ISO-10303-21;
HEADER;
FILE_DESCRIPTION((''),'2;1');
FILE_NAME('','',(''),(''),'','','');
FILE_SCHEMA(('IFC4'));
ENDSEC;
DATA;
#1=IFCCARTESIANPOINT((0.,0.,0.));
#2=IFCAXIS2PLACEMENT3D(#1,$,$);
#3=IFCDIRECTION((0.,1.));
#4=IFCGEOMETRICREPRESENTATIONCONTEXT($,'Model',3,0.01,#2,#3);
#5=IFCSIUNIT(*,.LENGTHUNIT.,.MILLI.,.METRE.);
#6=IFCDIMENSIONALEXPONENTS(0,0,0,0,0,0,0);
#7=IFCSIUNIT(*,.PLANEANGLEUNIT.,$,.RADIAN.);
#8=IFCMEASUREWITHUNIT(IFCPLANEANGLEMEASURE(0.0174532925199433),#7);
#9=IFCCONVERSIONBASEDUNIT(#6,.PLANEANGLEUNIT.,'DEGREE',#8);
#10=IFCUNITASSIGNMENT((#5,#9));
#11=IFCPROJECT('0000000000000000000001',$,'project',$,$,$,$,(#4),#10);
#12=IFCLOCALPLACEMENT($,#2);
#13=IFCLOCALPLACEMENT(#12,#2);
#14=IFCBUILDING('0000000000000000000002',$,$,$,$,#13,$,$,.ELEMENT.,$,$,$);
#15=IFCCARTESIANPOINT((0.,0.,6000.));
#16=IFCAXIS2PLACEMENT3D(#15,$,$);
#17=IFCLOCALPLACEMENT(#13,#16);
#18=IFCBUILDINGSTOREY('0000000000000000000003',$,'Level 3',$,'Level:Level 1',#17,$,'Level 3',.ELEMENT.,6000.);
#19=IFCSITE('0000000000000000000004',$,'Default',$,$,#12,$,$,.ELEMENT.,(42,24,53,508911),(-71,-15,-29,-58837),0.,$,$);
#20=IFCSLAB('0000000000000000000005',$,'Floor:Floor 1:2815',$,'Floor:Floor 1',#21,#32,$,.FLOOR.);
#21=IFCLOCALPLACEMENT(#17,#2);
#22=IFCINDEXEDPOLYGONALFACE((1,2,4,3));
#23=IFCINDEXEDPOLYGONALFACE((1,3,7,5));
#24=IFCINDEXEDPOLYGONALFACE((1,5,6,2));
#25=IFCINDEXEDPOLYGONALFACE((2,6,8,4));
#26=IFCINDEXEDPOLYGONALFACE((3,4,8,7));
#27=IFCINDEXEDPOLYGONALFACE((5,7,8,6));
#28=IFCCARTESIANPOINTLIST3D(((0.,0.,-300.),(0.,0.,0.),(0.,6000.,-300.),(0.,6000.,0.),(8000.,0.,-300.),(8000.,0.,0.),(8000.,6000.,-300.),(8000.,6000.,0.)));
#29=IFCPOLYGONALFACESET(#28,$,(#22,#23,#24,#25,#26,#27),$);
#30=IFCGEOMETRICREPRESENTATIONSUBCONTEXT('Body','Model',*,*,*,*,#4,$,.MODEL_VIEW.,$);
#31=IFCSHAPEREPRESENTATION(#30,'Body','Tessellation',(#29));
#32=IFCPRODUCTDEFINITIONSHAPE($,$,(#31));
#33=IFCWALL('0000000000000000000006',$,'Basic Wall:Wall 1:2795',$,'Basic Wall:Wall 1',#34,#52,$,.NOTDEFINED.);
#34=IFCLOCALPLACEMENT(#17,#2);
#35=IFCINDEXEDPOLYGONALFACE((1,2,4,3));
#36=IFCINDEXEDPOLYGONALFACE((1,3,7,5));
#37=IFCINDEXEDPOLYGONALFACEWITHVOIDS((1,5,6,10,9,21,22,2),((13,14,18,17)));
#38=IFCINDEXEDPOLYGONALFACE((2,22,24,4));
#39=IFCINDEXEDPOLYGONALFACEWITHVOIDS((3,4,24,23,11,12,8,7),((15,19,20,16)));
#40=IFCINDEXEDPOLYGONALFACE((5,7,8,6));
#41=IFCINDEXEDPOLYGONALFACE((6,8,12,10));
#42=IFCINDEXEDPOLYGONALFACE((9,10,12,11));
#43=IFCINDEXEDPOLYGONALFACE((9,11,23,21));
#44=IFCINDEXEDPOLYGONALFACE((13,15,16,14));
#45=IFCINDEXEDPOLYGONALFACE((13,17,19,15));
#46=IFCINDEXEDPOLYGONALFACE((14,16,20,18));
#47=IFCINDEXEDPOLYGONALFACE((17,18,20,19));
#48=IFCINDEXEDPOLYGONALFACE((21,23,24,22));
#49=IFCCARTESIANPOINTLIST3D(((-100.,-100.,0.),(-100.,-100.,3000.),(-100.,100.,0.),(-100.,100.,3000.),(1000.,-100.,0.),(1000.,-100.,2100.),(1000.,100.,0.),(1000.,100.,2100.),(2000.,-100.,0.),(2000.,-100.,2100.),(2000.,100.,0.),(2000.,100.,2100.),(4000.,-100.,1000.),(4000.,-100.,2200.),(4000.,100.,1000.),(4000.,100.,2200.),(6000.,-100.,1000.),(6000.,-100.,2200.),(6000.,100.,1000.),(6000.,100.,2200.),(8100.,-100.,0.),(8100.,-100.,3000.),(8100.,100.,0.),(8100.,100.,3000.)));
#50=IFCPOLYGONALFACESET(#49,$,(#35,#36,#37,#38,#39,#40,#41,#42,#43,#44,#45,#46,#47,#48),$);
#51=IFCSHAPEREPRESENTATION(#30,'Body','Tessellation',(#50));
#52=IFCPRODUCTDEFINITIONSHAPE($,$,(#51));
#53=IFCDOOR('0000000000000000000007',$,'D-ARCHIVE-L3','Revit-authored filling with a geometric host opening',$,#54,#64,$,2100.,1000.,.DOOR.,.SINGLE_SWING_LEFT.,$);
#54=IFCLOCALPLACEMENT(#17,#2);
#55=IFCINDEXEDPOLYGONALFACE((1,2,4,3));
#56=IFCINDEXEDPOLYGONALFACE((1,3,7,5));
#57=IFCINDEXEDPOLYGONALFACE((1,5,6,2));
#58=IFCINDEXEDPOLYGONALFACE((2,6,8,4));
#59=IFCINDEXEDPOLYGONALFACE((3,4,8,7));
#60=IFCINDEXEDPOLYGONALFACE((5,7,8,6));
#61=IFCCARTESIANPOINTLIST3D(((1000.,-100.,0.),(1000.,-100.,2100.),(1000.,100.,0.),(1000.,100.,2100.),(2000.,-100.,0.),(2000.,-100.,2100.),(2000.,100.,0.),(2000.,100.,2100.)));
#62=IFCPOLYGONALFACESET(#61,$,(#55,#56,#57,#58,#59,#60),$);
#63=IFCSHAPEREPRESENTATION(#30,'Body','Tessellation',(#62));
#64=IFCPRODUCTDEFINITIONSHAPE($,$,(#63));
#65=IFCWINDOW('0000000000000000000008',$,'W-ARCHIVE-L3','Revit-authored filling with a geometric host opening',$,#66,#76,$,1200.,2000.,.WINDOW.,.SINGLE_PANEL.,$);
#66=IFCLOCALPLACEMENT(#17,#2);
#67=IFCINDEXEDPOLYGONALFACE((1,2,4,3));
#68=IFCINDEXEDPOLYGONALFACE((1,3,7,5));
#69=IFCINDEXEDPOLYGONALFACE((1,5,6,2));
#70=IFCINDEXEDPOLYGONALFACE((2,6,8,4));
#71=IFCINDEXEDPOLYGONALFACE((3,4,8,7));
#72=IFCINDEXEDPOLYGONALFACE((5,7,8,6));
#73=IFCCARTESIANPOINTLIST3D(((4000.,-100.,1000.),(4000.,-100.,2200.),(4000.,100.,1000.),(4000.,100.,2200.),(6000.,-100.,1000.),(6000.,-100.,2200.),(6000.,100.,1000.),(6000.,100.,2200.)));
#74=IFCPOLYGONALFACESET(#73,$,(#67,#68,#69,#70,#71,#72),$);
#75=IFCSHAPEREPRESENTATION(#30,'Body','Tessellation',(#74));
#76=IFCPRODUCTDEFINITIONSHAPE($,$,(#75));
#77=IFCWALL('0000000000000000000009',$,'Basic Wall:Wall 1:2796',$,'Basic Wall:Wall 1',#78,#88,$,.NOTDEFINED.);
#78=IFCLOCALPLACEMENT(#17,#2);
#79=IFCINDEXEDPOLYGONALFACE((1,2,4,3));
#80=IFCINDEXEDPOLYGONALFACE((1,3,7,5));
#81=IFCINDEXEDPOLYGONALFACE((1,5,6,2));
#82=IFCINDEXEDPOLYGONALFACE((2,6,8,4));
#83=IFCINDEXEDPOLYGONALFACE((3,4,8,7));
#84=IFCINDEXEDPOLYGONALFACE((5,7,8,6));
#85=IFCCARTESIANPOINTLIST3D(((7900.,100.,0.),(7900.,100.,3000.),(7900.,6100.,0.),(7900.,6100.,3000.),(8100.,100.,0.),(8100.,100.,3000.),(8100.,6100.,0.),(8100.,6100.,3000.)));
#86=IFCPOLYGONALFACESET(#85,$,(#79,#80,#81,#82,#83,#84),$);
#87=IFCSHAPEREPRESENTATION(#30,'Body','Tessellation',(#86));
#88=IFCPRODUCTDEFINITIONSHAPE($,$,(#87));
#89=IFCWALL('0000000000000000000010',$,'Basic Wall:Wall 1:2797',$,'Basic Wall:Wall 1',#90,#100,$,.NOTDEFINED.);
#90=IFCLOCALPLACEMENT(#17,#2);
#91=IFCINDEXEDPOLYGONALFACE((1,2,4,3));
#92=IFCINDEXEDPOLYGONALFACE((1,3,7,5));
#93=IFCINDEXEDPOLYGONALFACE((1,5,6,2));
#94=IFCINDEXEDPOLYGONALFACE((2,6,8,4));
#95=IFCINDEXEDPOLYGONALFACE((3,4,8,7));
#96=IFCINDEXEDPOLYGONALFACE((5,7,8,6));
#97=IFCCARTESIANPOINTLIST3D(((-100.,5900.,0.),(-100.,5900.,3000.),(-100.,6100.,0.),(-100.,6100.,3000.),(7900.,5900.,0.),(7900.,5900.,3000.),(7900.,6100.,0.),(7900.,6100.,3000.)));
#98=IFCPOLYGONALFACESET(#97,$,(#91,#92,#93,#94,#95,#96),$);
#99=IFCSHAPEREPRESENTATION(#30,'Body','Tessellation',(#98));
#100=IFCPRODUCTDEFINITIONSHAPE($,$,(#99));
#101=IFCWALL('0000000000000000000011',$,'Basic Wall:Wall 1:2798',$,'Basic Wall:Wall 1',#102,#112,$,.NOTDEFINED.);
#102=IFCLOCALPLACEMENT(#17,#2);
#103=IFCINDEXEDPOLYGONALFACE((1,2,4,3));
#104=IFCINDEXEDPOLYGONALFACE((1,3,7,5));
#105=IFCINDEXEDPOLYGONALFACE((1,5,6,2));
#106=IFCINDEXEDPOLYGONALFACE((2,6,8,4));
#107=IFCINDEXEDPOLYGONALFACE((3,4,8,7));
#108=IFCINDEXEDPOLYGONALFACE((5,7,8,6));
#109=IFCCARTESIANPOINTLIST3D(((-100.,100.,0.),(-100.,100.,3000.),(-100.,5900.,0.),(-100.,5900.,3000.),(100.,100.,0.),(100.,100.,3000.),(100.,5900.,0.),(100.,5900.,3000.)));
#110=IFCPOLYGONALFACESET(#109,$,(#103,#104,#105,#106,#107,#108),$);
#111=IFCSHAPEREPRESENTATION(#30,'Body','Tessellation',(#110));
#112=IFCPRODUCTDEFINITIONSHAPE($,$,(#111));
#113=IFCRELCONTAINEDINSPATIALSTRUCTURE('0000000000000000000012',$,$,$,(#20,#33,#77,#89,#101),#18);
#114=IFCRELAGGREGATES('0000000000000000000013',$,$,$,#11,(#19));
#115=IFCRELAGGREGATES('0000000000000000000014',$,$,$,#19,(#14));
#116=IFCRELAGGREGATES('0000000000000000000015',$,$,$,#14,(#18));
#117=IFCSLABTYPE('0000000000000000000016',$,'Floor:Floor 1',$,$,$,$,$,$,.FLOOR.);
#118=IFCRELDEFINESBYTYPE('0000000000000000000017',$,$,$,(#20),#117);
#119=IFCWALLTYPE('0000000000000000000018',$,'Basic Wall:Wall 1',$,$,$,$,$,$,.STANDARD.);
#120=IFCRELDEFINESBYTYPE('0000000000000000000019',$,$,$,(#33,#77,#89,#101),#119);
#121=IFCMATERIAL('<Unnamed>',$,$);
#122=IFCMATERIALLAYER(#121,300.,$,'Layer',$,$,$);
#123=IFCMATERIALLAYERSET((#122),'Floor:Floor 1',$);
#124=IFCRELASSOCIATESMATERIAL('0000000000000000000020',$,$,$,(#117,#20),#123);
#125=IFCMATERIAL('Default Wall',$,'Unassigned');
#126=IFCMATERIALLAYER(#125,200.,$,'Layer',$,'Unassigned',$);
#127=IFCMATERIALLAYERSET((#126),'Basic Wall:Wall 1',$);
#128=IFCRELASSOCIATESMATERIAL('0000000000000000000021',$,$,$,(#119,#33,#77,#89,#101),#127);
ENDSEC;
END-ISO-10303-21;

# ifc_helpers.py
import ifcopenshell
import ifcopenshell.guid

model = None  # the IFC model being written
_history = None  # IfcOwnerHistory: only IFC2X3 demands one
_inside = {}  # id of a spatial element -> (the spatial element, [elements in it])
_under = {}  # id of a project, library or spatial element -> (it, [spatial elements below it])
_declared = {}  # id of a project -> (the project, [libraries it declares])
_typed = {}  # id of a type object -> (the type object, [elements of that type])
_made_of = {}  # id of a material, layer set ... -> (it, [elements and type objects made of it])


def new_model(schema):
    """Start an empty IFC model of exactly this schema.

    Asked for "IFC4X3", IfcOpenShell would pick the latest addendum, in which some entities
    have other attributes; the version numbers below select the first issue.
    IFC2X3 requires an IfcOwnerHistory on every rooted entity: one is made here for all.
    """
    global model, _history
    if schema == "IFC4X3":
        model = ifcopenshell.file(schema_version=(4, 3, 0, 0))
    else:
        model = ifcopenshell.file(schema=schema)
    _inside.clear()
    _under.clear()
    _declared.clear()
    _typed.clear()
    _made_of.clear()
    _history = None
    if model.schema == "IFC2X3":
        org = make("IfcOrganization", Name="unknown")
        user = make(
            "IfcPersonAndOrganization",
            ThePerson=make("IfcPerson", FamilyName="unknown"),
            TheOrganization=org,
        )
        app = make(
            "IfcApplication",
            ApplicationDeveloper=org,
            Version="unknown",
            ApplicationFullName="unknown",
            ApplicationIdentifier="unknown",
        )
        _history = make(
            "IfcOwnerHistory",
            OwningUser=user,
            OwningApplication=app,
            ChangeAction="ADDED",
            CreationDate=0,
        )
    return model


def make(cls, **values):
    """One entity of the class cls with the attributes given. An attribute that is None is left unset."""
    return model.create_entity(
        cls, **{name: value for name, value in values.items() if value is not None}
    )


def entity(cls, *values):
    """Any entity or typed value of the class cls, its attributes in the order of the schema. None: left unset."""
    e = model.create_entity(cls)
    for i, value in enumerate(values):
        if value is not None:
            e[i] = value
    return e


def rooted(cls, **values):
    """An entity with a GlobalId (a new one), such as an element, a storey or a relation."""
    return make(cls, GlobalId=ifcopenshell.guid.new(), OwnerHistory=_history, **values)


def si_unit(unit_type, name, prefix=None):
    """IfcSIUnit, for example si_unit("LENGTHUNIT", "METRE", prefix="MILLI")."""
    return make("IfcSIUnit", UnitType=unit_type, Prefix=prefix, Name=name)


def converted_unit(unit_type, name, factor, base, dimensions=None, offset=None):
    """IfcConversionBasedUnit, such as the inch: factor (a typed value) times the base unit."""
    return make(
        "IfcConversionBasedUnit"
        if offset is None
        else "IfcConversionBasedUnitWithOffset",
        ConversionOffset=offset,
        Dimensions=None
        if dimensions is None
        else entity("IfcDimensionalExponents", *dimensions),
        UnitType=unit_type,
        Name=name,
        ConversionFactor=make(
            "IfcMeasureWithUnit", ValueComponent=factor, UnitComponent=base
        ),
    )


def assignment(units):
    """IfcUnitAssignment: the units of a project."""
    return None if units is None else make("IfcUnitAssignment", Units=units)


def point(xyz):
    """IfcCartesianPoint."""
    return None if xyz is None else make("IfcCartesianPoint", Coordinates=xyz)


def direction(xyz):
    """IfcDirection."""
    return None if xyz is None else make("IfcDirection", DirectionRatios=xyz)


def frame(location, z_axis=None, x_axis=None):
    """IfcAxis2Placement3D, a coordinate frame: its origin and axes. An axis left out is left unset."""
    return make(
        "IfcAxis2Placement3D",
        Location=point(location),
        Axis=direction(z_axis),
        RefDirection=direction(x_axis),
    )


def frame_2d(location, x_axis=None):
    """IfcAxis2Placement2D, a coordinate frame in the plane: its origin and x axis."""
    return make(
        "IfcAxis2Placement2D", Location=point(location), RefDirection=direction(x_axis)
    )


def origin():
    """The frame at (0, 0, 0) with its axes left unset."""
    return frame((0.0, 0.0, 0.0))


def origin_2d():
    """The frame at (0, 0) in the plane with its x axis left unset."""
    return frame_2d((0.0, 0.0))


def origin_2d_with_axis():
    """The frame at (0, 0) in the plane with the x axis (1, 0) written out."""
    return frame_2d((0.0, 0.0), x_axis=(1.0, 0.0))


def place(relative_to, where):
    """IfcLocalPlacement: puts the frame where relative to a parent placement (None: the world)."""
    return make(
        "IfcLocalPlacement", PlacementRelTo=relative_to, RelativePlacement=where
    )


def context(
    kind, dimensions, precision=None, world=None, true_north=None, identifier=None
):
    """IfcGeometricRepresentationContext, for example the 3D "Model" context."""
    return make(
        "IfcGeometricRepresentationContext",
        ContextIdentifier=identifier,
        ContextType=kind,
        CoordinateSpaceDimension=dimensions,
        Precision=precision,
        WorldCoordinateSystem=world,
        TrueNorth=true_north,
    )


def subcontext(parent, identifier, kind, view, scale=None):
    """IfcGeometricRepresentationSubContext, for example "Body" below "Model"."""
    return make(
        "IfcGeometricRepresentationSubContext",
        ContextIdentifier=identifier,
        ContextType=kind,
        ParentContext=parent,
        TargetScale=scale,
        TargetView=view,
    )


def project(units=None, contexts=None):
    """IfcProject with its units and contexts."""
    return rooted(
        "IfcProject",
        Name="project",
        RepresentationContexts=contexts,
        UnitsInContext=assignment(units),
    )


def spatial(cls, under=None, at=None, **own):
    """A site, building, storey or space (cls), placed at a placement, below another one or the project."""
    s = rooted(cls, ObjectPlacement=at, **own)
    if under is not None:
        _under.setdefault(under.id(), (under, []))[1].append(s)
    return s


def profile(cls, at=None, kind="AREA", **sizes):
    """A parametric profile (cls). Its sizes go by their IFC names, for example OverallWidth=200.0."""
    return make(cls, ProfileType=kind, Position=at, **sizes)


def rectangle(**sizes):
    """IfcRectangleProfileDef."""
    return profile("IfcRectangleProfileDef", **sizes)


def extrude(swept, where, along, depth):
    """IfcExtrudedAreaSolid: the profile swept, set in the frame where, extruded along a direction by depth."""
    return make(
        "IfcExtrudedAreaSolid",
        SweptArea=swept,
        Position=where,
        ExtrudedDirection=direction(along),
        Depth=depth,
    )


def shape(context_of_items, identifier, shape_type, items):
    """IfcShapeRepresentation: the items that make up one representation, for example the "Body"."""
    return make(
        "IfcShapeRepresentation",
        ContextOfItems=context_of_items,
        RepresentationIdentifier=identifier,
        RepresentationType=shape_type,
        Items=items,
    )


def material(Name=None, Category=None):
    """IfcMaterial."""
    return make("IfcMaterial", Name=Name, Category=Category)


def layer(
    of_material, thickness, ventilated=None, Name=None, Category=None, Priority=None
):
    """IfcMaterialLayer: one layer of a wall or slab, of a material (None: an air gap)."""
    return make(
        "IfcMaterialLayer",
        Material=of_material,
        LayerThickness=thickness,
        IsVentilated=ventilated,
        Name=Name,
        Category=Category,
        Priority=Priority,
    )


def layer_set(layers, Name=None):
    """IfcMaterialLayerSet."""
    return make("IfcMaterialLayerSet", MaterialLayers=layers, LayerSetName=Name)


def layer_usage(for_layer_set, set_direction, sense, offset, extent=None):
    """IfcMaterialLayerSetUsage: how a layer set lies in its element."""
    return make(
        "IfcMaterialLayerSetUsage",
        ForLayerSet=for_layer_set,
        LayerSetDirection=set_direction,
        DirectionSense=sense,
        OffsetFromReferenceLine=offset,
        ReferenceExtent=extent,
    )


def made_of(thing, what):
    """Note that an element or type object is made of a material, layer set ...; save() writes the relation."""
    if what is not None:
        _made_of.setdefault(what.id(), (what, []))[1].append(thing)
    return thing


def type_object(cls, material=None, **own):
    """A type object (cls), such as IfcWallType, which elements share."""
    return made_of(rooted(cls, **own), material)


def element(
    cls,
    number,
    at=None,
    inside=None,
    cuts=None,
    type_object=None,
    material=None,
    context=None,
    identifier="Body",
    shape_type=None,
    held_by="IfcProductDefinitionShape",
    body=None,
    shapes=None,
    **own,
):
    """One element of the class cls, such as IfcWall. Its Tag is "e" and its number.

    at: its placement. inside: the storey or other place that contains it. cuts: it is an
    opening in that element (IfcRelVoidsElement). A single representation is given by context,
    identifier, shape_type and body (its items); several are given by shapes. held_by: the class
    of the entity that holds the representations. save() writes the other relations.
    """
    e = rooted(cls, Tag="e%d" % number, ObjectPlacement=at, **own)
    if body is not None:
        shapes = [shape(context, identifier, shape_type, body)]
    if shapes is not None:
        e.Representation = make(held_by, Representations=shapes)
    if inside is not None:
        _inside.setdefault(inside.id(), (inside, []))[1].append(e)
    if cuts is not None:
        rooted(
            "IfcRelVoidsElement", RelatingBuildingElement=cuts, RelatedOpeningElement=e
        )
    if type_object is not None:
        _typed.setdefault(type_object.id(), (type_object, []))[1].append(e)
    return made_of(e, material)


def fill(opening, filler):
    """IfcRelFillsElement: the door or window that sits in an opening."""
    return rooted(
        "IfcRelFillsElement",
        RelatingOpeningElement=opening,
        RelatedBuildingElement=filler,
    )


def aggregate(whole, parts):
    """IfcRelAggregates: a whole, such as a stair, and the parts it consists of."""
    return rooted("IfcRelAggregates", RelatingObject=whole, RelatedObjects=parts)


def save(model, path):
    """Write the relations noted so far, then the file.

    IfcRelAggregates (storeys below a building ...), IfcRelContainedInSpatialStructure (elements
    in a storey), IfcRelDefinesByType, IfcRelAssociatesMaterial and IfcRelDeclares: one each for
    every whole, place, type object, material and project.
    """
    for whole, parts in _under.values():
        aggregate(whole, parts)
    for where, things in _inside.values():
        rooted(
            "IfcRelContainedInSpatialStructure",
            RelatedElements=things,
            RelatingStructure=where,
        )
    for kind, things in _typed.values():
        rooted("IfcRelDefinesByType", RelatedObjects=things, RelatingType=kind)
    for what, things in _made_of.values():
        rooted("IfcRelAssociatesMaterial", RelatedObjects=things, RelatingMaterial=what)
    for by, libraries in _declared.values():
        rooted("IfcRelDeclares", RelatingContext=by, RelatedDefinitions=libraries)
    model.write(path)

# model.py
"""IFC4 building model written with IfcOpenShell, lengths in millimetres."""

from ifc_helpers import new_model, entity, si_unit, converted_unit, direction, frame, frame_2d, origin, origin_2d, origin_2d_with_axis, place, context, subcontext, project, spatial, rectangle, extrude, material, layer, layer_set, layer_usage, type_object, element, fill, save


model = new_model("IFC4")

# Units and contexts
model_context = context("Model", 3, precision=0.01, world=origin(), true_north=direction((0.0, 1.0)))
body_context = subcontext(model_context, "Body", "Model", "MODEL_VIEW")
ifc_project = project(units=[si_unit("LENGTHUNIT", "METRE", prefix="MILLI"), converted_unit("PLANEANGLEUNIT", "DEGREE", entity("IfcPlaneAngleMeasure", 0.0174532925199433), si_unit("PLANEANGLEUNIT", "RADIAN"), dimensions=[0, 0, 0, 0, 0, 0, 0])], contexts=[model_context])

# Site, building, storey
site_placement = place(None, origin())
site = spatial("IfcSite", under=ifc_project, at=site_placement, Name="Default", CompositionType="ELEMENT", RefLatitude=(42, 24, 53, 508911), RefLongitude=(-71, -15, -29, -58837), RefElevation=0.0)
building_placement = place(site_placement, origin())
building = spatial("IfcBuilding", under=site, at=building_placement, CompositionType="ELEMENT")
storey_placement = place(building_placement, frame((0.0, 0.0, 6000.0)))
storey = spatial("IfcBuildingStorey", under=building, at=storey_placement, Name="Level 3", ObjectType="Level:Level 1", LongName="Level 3", CompositionType="ELEMENT", Elevation=6000.0)

# Slab
ifc_material_1 = material(Name="<Unnamed>")
ifc_layer_1 = layer(ifc_material_1, 300.0, Name="Layer")
ifc_layer_set_1 = layer_set([ifc_layer_1], Name="Floor:Floor 1")
ifc_layer_usage_1 = layer_usage(ifc_layer_set_1, "AXIS3", "POSITIVE", 0.0)
slab_type = type_object("IfcSlabType", Name="Floor:Floor 1", PredefinedType="FLOOR", material=ifc_layer_set_1)
slab_placement = place(storey_placement, origin())
element("IfcSlab", 1, at=slab_placement, inside=storey, type_object=slab_type, material=ifc_layer_usage_1, Name="Floor:Floor 1:2815", ObjectType="Floor:Floor 1", PredefinedType="FLOOR", context=body_context, shape_type="SweptSolid", body=[
    extrude(rectangle(XDim=6000.0, YDim=8000.0, at=origin_2d_with_axis()), frame((4000.0, 3000.0, 0.0), z_axis=(0.0, 0.0, -1.0), x_axis=(0.0, 1.0, 0.0)), (0.0, 0.0, 1.0), 300.0),
])

# Wall, openings, door, window
ifc_material_2 = material(Name="Default Wall", Category="Unassigned")
ifc_layer_2 = layer(ifc_material_2, 200.0, Name="Layer", Category="Unassigned")
ifc_layer_set_2 = layer_set([ifc_layer_2], Name="Basic Wall:Wall 1")
ifc_layer_usage_2 = layer_usage(ifc_layer_set_2, "AXIS2", "NEGATIVE", 100.0)
wall_type = type_object("IfcWallType", Name="Basic Wall:Wall 1", PredefinedType="STANDARD", material=ifc_layer_set_2)
wall_1_placement = place(storey_placement, frame((-100.0, 0.0, 0.0)))
wall_1 = element("IfcWall", 2, at=wall_1_placement, inside=storey, type_object=wall_type, material=ifc_layer_usage_2, Name="Basic Wall:Wall 1:2795", ObjectType="Basic Wall:Wall 1", PredefinedType="NOTDEFINED", context=body_context, shape_type="SweptSolid", body=[
    extrude(rectangle(XDim=8200.0, YDim=200.0, at=frame_2d((4100.0, 0.0), x_axis=(-1.0, 0.0))), origin(), (0.0, 0.0, 1.0), 3000.0),
])
opening_1_placement = place(storey_placement, frame((1000.0, -100.0, 0.0)))
opening_1 = element("IfcOpeningElement", 3, at=opening_1_placement, cuts=wall_1, PredefinedType="OPENING", context=body_context, shape_type="SweptSolid", body=[
    extrude(rectangle(XDim=1000.0, YDim=200.0, at=origin_2d()), frame((500.0, 100.0, 0.0)), (0.0, 0.0, 1.0), 2100.0),
])
opening_2_placement = place(storey_placement, frame((4000.0, -100.0, 1000.0)))
opening_2 = element("IfcOpeningElement", 4, at=opening_2_placement, cuts=wall_1, PredefinedType="OPENING", context=body_context, shape_type="SweptSolid", body=[
    extrude(rectangle(XDim=2000.0, YDim=200.0, at=origin_2d()), frame((1000.0, 100.0, 0.0)), (0.0, 0.0, 1.0), 1200.0),
])
door_placement = place(storey_placement, frame((1000.0, -100.0, 0.0)))
door = element("IfcDoor", 5, at=door_placement, Name="D-ARCHIVE-L3", Description="Revit-authored filling with a geometric host opening", OperationType="SINGLE_SWING_LEFT", OverallHeight=2100.0, OverallWidth=1000.0, PredefinedType="DOOR", context=body_context, shape_type="SweptSolid", body=[
    extrude(rectangle(XDim=1000.0, YDim=200.0, at=origin_2d()), frame((500.0, 100.0, 0.0)), (0.0, 0.0, 1.0), 2100.0),
])
fill(opening_1, door)
window_placement = place(storey_placement, frame((4000.0, -100.0, 1000.0)))
window = element("IfcWindow", 6, at=window_placement, Name="W-ARCHIVE-L3", Description="Revit-authored filling with a geometric host opening", OverallHeight=1200.0, OverallWidth=2000.0, PartitioningType="SINGLE_PANEL", PredefinedType="WINDOW", context=body_context, shape_type="SweptSolid", body=[
    extrude(rectangle(XDim=2000.0, YDim=200.0, at=origin_2d()), frame((1000.0, 100.0, 0.0)), (0.0, 0.0, 1.0), 1200.0),
])
fill(opening_2, window)

# Walls
ifc_layer_usage_3 = layer_usage(ifc_layer_set_2, "AXIS2", "NEGATIVE", 100.0)
wall_2_placement = place(storey_placement, frame((8000.0, 100.0, 0.0), z_axis=(0.0, 0.0, 1.0), x_axis=(0.0, 1.0, 0.0)))
element("IfcWall", 7, at=wall_2_placement, inside=storey, type_object=wall_type, material=ifc_layer_usage_3, Name="Basic Wall:Wall 1:2796", ObjectType="Basic Wall:Wall 1", PredefinedType="NOTDEFINED", context=body_context, shape_type="SweptSolid", body=[
    extrude(rectangle(XDim=6000.0, YDim=200.0, at=frame_2d((3000.0, 0.0), x_axis=(-1.0, 0.0))), origin(), (0.0, 0.0, 1.0), 3000.0),
])
ifc_layer_usage_4 = layer_usage(ifc_layer_set_2, "AXIS2", "NEGATIVE", 100.0)
wall_3_placement = place(storey_placement, frame((7900.0, 6000.0, 0.0), z_axis=(0.0, 0.0, 1.0), x_axis=(-1.0, 0.0, 0.0)))
element("IfcWall", 8, at=wall_3_placement, inside=storey, type_object=wall_type, material=ifc_layer_usage_4, Name="Basic Wall:Wall 1:2797", ObjectType="Basic Wall:Wall 1", PredefinedType="NOTDEFINED", context=body_context, shape_type="SweptSolid", body=[
    extrude(rectangle(XDim=8000.0, YDim=200.0, at=frame_2d((4000.0, 0.0), x_axis=(-1.0, 0.0))), origin(), (0.0, 0.0, 1.0), 3000.0),
])
ifc_layer_usage_5 = layer_usage(ifc_layer_set_2, "AXIS2", "NEGATIVE", 100.0)
wall_4_placement = place(storey_placement, frame((0.0, 5900.0, 0.0), z_axis=(0.0, 0.0, 1.0), x_axis=(0.0, -1.0, 0.0)))
element("IfcWall", 9, at=wall_4_placement, inside=storey, type_object=wall_type, material=ifc_layer_usage_5, Name="Basic Wall:Wall 1:2798", ObjectType="Basic Wall:Wall 1", PredefinedType="NOTDEFINED", context=body_context, shape_type="SweptSolid", body=[
    extrude(rectangle(XDim=5800.0, YDim=200.0, at=frame_2d((2900.0, 0.0), x_axis=(-1.0, 0.0))), origin(), (0.0, 0.0, 1.0), 3000.0),
])

save(model, "model.ifc")
